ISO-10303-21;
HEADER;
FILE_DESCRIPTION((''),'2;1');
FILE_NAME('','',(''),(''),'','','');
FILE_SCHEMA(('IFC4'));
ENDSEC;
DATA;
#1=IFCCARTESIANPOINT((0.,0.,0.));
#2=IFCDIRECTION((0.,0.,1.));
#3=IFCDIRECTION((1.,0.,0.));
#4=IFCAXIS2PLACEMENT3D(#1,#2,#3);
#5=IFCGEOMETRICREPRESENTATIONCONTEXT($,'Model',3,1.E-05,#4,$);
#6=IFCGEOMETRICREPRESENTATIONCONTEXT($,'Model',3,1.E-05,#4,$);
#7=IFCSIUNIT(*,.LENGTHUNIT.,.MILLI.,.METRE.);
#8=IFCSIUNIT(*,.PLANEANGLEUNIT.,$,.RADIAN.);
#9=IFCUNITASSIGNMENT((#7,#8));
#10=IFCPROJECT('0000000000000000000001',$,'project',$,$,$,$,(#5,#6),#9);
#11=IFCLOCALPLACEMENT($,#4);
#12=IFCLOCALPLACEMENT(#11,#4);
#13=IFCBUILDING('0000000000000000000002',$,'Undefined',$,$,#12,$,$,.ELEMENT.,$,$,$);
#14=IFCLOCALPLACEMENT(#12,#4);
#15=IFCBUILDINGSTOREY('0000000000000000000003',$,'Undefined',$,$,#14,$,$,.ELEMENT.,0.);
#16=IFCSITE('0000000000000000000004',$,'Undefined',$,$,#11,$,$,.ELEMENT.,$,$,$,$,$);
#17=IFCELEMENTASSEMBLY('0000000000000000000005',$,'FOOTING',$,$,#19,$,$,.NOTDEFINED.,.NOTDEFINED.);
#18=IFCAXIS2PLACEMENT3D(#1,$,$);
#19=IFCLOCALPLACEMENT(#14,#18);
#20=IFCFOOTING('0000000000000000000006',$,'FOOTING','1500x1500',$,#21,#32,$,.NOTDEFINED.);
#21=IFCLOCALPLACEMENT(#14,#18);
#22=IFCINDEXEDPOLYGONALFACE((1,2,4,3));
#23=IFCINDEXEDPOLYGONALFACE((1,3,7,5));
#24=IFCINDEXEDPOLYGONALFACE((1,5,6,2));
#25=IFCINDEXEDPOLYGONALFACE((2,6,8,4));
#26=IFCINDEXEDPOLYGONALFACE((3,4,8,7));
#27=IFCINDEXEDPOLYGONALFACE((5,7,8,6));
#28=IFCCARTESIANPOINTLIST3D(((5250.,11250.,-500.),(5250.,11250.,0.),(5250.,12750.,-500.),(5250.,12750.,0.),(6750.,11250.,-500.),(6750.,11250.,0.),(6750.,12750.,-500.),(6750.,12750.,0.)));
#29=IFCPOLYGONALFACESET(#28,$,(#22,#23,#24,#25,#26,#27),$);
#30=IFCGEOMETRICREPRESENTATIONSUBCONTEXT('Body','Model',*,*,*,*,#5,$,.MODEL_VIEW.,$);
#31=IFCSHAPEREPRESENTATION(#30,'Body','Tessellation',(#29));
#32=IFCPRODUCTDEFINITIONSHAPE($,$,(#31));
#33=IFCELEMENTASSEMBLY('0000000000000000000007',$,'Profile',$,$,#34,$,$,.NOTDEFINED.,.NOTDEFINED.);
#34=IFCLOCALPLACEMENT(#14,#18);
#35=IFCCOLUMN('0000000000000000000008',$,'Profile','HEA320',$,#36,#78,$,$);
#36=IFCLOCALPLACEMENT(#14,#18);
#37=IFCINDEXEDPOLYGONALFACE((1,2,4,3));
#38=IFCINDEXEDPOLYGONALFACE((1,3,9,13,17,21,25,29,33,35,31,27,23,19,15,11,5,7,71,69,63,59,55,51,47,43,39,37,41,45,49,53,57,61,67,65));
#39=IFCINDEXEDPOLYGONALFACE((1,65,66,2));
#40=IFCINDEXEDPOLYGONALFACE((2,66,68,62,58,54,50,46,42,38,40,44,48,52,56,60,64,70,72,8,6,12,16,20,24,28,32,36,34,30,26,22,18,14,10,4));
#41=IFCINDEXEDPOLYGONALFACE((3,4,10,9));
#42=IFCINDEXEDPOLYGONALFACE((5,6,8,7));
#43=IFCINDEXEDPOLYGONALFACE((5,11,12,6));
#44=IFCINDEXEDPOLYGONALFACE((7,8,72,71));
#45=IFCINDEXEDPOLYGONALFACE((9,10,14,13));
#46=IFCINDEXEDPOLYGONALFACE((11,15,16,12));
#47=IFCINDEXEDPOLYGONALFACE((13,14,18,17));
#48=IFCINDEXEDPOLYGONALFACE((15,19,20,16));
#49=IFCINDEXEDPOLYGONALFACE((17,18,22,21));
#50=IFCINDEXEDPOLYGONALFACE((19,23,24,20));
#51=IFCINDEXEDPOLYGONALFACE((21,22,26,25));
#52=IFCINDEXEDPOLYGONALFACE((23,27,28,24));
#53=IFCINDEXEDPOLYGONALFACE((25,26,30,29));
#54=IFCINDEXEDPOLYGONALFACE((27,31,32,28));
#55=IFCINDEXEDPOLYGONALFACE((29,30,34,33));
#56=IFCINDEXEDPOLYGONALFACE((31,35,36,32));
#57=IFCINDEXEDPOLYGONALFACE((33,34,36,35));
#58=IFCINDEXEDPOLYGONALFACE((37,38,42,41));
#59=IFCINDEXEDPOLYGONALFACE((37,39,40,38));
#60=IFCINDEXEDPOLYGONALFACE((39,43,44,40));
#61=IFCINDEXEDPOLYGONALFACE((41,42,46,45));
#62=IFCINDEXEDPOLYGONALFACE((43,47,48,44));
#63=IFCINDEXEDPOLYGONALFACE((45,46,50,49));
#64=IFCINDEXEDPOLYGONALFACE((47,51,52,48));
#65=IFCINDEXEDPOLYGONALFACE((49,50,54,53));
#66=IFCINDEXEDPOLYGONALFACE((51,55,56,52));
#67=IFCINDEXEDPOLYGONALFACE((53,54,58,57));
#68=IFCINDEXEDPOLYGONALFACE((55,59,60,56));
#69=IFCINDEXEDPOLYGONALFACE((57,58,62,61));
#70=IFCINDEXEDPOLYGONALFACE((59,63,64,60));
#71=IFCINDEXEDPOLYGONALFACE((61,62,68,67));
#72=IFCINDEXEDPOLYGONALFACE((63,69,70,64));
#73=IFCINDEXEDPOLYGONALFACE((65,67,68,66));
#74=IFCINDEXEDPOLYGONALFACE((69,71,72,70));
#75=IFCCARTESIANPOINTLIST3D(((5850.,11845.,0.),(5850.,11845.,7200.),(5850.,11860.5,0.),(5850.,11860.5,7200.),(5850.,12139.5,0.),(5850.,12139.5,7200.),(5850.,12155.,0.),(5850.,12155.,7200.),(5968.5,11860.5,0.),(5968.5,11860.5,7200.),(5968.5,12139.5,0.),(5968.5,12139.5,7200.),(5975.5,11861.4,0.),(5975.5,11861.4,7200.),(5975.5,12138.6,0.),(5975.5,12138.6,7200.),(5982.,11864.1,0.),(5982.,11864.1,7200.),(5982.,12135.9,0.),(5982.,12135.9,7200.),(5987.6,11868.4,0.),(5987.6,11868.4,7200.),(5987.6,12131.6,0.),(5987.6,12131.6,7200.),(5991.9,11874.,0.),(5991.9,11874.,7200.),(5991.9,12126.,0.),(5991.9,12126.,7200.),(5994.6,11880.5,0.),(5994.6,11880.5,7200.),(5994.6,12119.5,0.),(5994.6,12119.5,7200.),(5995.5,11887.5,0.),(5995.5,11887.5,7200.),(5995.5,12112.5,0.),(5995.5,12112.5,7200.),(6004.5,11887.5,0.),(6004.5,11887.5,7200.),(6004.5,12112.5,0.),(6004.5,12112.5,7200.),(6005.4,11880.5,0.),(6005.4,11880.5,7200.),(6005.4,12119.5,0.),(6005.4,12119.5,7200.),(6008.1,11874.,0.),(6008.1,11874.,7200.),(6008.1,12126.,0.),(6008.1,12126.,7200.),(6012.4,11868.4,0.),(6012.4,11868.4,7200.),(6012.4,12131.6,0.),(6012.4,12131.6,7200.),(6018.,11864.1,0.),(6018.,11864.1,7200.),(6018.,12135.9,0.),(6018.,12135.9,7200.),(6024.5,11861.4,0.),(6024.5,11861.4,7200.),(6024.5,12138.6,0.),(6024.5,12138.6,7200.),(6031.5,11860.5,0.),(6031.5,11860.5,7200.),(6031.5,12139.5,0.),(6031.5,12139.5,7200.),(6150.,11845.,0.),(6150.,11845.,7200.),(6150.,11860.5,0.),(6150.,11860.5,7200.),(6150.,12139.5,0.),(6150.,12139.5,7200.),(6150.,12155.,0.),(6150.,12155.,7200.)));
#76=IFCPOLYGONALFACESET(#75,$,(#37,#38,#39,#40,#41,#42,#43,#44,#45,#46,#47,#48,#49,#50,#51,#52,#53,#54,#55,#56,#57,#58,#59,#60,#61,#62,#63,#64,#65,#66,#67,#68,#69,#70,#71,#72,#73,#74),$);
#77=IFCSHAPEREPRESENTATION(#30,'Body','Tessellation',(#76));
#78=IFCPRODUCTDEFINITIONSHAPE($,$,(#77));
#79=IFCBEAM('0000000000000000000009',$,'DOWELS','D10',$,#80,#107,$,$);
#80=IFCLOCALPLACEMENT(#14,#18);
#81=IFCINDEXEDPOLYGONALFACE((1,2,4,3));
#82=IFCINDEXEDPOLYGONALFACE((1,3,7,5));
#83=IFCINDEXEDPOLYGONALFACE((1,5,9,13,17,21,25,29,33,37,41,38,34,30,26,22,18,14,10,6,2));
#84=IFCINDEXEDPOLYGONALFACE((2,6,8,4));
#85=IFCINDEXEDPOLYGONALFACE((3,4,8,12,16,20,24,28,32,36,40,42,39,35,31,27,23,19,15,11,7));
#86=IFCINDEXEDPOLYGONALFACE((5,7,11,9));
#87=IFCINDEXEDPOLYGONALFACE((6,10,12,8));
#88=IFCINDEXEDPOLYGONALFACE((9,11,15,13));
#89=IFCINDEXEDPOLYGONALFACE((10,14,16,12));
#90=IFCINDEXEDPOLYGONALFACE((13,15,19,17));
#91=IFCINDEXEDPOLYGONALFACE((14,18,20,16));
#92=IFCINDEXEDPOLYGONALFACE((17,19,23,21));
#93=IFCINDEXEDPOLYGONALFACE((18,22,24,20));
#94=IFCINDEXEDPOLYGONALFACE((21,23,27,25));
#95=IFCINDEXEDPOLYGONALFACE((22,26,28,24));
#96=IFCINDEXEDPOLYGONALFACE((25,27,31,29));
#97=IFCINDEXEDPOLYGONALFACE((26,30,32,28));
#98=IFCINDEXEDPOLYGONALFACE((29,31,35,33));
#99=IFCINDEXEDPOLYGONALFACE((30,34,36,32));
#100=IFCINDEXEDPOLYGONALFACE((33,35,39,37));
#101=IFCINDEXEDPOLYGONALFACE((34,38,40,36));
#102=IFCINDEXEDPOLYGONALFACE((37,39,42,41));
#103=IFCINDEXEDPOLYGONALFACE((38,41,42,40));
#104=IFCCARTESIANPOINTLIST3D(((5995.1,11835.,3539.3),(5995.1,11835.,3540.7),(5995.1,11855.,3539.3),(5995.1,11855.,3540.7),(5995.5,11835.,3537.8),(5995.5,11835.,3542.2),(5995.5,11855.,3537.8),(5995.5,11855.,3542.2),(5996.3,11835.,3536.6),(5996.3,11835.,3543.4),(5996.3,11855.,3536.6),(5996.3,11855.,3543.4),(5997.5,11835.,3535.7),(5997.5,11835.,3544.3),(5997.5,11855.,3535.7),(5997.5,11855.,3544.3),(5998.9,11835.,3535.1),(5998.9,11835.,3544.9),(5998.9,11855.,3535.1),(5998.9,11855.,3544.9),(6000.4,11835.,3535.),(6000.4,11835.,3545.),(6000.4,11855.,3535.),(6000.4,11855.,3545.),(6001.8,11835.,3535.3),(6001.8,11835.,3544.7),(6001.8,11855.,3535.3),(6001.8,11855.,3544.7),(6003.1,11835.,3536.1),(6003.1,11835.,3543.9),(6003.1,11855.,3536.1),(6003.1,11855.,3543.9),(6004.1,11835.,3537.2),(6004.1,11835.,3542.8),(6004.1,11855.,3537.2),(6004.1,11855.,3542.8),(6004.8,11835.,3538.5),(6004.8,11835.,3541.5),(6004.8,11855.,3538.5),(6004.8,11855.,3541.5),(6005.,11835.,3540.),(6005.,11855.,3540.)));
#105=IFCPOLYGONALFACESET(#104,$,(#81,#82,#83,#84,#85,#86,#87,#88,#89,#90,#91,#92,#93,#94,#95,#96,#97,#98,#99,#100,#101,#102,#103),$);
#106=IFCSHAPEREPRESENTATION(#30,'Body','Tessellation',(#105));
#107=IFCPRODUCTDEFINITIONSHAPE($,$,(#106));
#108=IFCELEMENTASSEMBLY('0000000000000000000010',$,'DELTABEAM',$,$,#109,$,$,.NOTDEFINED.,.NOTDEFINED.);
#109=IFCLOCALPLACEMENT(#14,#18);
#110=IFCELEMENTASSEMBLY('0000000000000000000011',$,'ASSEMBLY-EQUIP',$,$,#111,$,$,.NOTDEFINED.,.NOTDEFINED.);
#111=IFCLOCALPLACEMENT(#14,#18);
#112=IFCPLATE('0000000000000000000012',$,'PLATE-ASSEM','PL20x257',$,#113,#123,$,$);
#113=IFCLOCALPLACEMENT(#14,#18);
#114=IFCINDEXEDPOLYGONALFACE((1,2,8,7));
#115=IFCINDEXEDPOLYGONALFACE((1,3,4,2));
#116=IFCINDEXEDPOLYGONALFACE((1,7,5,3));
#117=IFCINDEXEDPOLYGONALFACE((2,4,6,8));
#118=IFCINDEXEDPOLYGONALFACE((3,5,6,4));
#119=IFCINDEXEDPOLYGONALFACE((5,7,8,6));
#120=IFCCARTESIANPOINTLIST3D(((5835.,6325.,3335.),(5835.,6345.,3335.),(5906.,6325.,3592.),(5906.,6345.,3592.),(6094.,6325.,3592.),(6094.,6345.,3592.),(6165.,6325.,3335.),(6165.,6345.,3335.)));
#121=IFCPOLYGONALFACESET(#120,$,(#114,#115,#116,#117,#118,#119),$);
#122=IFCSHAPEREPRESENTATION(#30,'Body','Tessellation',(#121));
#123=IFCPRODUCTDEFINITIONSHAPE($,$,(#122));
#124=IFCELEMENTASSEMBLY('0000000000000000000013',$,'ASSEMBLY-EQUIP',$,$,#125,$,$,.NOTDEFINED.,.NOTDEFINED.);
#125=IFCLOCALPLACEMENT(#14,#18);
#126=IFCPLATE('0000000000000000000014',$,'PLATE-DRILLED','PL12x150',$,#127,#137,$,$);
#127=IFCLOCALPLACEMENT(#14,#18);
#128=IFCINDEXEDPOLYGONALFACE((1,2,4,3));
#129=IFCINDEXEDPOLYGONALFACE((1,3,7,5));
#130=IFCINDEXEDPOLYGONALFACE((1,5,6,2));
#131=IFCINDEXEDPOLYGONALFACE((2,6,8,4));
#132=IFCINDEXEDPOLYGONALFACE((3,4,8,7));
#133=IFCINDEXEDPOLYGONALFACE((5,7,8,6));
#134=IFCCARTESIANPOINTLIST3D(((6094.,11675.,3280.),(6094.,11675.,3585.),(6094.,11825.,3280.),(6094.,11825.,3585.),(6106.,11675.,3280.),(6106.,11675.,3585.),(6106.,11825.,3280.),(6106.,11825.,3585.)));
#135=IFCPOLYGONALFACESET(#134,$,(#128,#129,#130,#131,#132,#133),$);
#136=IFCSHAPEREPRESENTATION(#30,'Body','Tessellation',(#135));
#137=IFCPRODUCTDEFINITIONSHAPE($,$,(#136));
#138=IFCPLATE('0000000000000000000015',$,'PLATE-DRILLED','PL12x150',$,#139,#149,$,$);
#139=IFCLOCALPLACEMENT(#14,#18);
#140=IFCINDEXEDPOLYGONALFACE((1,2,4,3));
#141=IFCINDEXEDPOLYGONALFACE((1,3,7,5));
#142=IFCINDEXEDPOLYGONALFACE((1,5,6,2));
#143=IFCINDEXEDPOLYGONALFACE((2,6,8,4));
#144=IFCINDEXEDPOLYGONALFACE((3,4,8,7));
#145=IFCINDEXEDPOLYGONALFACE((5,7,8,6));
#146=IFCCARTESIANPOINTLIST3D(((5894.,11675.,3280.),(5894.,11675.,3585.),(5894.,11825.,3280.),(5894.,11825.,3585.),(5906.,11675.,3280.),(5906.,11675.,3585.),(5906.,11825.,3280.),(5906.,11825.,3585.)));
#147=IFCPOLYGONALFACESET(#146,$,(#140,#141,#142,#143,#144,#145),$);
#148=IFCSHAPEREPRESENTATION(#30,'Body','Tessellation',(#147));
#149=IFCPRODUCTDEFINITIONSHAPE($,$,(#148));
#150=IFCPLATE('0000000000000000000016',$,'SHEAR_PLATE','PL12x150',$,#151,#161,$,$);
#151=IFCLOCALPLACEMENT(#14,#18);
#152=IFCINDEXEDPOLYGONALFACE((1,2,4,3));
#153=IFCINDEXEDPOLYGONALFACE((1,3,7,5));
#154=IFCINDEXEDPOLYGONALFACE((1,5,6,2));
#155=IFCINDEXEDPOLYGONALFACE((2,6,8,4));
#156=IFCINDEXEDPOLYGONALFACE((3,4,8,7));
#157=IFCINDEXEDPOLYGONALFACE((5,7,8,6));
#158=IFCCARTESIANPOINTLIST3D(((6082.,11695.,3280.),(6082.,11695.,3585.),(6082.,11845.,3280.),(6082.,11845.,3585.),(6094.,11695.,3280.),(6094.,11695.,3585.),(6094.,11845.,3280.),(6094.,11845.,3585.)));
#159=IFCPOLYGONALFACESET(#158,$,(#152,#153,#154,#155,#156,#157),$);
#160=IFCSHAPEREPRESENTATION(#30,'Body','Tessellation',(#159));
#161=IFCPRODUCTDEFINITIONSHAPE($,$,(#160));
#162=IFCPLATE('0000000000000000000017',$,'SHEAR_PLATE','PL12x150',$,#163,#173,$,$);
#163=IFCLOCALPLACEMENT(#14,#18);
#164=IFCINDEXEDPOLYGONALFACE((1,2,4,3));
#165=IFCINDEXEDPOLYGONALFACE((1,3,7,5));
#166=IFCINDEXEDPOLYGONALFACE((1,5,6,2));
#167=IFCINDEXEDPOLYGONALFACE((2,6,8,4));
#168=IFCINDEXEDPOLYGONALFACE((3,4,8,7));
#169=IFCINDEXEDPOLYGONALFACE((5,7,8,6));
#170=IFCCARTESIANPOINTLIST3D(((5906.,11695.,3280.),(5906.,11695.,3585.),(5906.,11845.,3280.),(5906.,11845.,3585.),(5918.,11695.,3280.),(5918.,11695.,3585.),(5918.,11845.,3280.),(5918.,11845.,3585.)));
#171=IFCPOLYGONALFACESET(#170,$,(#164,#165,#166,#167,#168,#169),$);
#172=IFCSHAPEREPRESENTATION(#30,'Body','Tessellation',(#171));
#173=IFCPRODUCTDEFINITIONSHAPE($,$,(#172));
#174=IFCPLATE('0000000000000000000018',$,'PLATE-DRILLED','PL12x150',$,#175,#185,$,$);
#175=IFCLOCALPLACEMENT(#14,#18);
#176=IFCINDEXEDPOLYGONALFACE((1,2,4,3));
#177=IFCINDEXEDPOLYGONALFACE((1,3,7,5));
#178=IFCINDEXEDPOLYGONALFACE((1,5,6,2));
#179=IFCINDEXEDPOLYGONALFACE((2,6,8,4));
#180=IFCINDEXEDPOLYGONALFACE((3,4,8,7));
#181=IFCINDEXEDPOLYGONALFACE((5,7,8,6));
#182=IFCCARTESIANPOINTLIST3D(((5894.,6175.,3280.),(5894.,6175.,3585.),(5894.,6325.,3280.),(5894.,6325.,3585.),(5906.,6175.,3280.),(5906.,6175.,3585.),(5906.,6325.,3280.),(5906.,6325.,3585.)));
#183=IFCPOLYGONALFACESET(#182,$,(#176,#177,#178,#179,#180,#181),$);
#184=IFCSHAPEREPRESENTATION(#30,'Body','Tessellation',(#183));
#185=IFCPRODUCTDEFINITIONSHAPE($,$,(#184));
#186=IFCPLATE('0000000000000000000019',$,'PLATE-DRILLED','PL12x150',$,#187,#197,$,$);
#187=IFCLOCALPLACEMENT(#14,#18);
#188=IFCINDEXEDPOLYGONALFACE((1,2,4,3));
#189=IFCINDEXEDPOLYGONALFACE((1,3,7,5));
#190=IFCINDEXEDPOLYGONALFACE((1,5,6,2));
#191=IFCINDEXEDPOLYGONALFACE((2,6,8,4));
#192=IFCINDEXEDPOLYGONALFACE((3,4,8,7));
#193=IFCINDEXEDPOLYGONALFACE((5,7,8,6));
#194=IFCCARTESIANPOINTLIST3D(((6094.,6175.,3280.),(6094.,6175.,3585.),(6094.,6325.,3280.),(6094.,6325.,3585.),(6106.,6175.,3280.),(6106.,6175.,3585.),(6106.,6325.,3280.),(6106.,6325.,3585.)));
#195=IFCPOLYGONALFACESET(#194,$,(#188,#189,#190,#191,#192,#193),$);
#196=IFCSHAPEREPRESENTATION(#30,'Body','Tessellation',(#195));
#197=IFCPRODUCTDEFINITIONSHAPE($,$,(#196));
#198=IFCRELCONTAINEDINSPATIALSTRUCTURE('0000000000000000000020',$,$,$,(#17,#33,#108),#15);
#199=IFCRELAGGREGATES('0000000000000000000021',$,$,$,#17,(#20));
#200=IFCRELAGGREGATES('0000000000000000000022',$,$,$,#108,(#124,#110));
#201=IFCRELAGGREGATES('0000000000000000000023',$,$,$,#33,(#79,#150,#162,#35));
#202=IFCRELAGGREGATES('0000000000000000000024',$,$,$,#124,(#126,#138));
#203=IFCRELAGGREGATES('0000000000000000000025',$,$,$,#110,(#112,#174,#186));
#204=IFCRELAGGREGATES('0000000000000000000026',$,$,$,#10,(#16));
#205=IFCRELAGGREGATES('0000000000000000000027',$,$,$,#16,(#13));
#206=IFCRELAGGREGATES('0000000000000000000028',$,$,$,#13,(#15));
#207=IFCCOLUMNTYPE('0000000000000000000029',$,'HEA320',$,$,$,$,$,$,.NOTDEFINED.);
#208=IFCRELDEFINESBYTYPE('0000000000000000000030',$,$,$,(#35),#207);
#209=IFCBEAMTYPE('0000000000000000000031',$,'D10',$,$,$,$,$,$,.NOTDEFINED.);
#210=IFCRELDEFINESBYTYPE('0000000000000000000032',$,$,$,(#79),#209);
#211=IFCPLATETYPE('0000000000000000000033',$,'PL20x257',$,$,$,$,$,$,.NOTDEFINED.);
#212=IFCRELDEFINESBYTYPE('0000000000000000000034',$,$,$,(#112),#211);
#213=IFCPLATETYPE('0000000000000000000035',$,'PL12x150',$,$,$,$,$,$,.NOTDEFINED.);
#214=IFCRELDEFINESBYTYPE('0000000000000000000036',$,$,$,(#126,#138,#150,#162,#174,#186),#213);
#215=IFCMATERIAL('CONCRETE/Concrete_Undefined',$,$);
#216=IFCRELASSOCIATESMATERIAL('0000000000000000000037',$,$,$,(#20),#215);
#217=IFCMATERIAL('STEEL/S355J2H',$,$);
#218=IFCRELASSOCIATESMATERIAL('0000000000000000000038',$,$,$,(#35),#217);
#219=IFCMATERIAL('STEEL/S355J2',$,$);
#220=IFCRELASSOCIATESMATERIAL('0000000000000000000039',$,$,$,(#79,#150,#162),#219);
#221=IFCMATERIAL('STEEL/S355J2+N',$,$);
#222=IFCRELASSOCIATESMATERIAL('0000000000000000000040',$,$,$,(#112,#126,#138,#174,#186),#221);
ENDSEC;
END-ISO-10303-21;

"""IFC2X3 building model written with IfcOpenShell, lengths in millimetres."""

from ifc_helpers import new_model, si_unit, frame, origin_with_axes, origin_2d_with_axis, place, context, subcontext, project, spatial, polyline, rectangle, circle, i_section, outline, extrude, material, type_object, element, aggregate, save


model = new_model("IFC2X3")

# Units and contexts
model_context_1 = context("Model", 3, precision=1e-05, world=origin_with_axes())
model_context_2 = context("Model", 3, precision=1e-05, world=origin_with_axes())
body_context = subcontext(model_context_1, "Body", "Model", "MODEL_VIEW")
ifc_project = project(units=[si_unit("LENGTHUNIT", "METRE", prefix="MILLI"), si_unit("PLANEANGLEUNIT", "RADIAN")], contexts=[model_context_1, model_context_2])

# Site, building, storey
site_placement = place(None, origin_with_axes())
site = spatial("IfcSite", under=ifc_project, at=site_placement, Name="Undefined", CompositionType="ELEMENT")
building_placement = place(site_placement, origin_with_axes())
building = spatial("IfcBuilding", under=site, at=building_placement, Name="Undefined", CompositionType="ELEMENT")
storey_placement = place(building_placement, origin_with_axes())
storey = spatial("IfcBuildingStorey", under=building, at=storey_placement, Name="Undefined", CompositionType="ELEMENT", Elevation=0.0)

# Element assembly, footing
assembly_1_placement = place(storey_placement, origin_with_axes())
assembly_1 = element("IfcElementAssembly", 1, at=assembly_1_placement, inside=storey, Name="FOOTING", AssemblyPlace="NOTDEFINED", PredefinedType="NOTDEFINED")
ifc_material_1 = material(Name="CONCRETE/Concrete_Undefined")
footing_placement = place(assembly_1_placement, frame((6000.0, 12000.0, -500.0), z_axis=(0.0, 1.0, 0.0), x_axis=(0.0, 0.0, 1.0)))
footing = element("IfcFooting", 2, at=footing_placement, material=ifc_material_1, Name="FOOTING", Description="1500x1500", PredefinedType="NOTDEFINED", context=body_context, shape_type="SweptSolid", body=[
    extrude(rectangle(XDim=1500.0, YDim=1500.0, at=origin_2d_with_axis()), frame((500.0, 0.0, 0.0), z_axis=(-1.0, 0.0, 0.0), x_axis=(0.0, -1.0, 0.0)), (0.0, 0.0, 1.0), 500.0),
])
aggregate(assembly_1, [footing])

# Element assembly, column, beam
assembly_2_placement = place(storey_placement, origin_with_axes())
assembly_2 = element("IfcElementAssembly", 3, at=assembly_2_placement, inside=storey, Name="Profile", AssemblyPlace="NOTDEFINED", PredefinedType="NOTDEFINED")
ifc_material_2 = material(Name="STEEL/S355J2H")
column_type = type_object("IfcColumnType", Name="HEA320", PredefinedType="NOTDEFINED")
column_placement = place(assembly_2_placement, frame((6000.0, 12000.0, 0.0), z_axis=(0.0, 0.0, 1.0), x_axis=(0.0, 1.0, 0.0)))
column = element("IfcColumn", 4, at=column_placement, type_object=column_type, material=ifc_material_2, Name="Profile", Description="HEA320", context=body_context, shape_type="SweptSolid", body=[
    extrude(i_section(OverallWidth=300.0, OverallDepth=310.0, WebThickness=9.0, FlangeThickness=15.5, FilletRadius=27.0, at=origin_2d_with_axis()), frame((0.0, 0.0, 7200.0), z_axis=(0.0, 0.0, -1.0), x_axis=(0.0, 1.0, 0.0)), (0.0, 0.0, 1.0), 7200.0),
])
ifc_material_3 = material(Name="STEEL/S355J2")
beam_type_1 = type_object("IfcBeamType", Name="D10", PredefinedType="NOTDEFINED")
beam_1_placement = place(assembly_2_placement, frame((6000.0, 11835.0, 3540.0), z_axis=(0.0, 0.0, 1.0), x_axis=(0.0, 1.0, 0.0)))
beam_1 = element("IfcBeam", 5, at=beam_1_placement, type_object=beam_type_1, material=ifc_material_3, Name="DOWELS", Description="D10", context=body_context, shape_type="SweptSolid", body=[
    extrude(circle(Radius=5.0, at=origin_2d_with_axis()), frame((20.0, 0.0, 0.0), z_axis=(-1.0, 0.0, 0.0), x_axis=(0.0, -1.0, 0.0)), (0.0, 0.0, 1.0), 20.0),
])

# Element assemblies, plates
assembly_3_placement = place(storey_placement, origin_with_axes())
assembly_3 = element("IfcElementAssembly", 6, at=assembly_3_placement, inside=storey, Name="DELTABEAM", AssemblyPlace="NOTDEFINED", PredefinedType="NOTDEFINED")
assembly_4_placement = place(assembly_3_placement, origin_with_axes())
assembly_4 = element("IfcElementAssembly", 7, at=assembly_4_placement, Name="ASSEMBLY-EQUIP", AssemblyPlace="NOTDEFINED", PredefinedType="NOTDEFINED")
ifc_material_4 = material(Name="STEEL/S355J2+N")
plate_type_1 = type_object("IfcPlateType", Name="PL20x257", PredefinedType="NOTDEFINED")
plate_1_placement = place(assembly_4_placement, frame((6165.0, 6335.0, 3335.0), z_axis=(0.0, 1.0, 0.0), x_axis=(-1.0, 0.0, 0.0)))
plate_1 = element("IfcPlate", 8, at=plate_1_placement, type_object=plate_type_1, material=ifc_material_4, Name="PLATE-ASSEM", Description="PL20x257", context=body_context, shape_type="SweptSolid", body=[
    extrude(outline(polyline([(0.0, 0.0), (330.0, 0.0), (259.0, 257.0), (71.0, 257.0), (0.0, 0.0)])), frame((0.0, 0.0, -10.0), z_axis=(0.0, 0.0, 1.0), x_axis=(1.0, 0.0, 0.0)), (0.0, 0.0, 1.0), 20.0),
])
assembly_5_placement = place(assembly_3_placement, origin_with_axes())
assembly_5 = element("IfcElementAssembly", 9, at=assembly_5_placement, Name="ASSEMBLY-EQUIP", AssemblyPlace="NOTDEFINED", PredefinedType="NOTDEFINED")
aggregate(assembly_3, [assembly_5, assembly_4])
plate_type_2 = type_object("IfcPlateType", Name="PL12x150", PredefinedType="NOTDEFINED")
plate_2_placement = place(assembly_5_placement, frame((6100.0, 11675.0, 3585.0), z_axis=(-1.0, 0.0, 0.0), x_axis=(0.0, 1.0, 0.0)))
plate_2 = element("IfcPlate", 10, at=plate_2_placement, type_object=plate_type_2, material=ifc_material_4, Name="PLATE-DRILLED", Description="PL12x150", context=body_context, shape_type="SweptSolid", body=[
    extrude(outline(polyline([(0.0, 0.0), (150.0, 0.0), (150.0, 0.0), (150.0, 305.0), (150.0, 305.0), (0.0, 305.0), (0.0, 305.0), (0.0, 0.0)])), frame((0.0, 0.0, -6.0), z_axis=(0.0, 0.0, 1.0), x_axis=(1.0, 0.0, 0.0)), (0.0, 0.0, 1.0), 12.0),
])
plate_3_placement = place(assembly_5_placement, frame((5900.0, 11675.0, 3585.0), z_axis=(-1.0, 0.0, 0.0), x_axis=(0.0, 1.0, 0.0)))
plate_3 = element("IfcPlate", 11, at=plate_3_placement, type_object=plate_type_2, material=ifc_material_4, Name="PLATE-DRILLED", Description="PL12x150", context=body_context, shape_type="SweptSolid", body=[
    extrude(outline(polyline([(0.0, 0.0), (150.0, 0.0), (150.0, 0.0), (150.0, 305.0), (150.0, 305.0), (0.0, 305.0), (0.0, 305.0), (0.0, 0.0)])), frame((0.0, 0.0, -6.0), z_axis=(0.0, 0.0, 1.0), x_axis=(1.0, 0.0, 0.0)), (0.0, 0.0, 1.0), 12.0),
])

# Plates
plate_4_placement = place(assembly_2_placement, frame((6088.0, 11845.0, 3585.0), z_axis=(1.0, 0.0, 0.0), x_axis=(0.0, -1.0, 0.0)))
plate_4 = element("IfcPlate", 12, at=plate_4_placement, type_object=plate_type_2, material=ifc_material_3, Name="SHEAR_PLATE", Description="PL12x150", context=body_context, shape_type="SweptSolid", body=[
    extrude(outline(polyline([(0.0, 0.0), (150.0, 0.0), (150.0, 0.0), (150.0, 305.0), (150.0, 305.0), (0.0, 305.0), (0.0, 305.0), (0.0, 0.0)])), frame((0.0, 0.0, -6.0), z_axis=(0.0, 0.0, 1.0), x_axis=(1.0, 0.0, 0.0)), (0.0, 0.0, 1.0), 12.0),
])
plate_5_placement = place(assembly_2_placement, frame((5912.0, 11845.0, 3585.0), z_axis=(1.0, 0.0, 0.0), x_axis=(0.0, -1.0, 0.0)))
plate_5 = element("IfcPlate", 13, at=plate_5_placement, type_object=plate_type_2, material=ifc_material_3, Name="SHEAR_PLATE", Description="PL12x150", context=body_context, shape_type="SweptSolid", body=[
    extrude(outline(polyline([(0.0, 0.0), (150.0, 0.0), (150.0, 0.0), (150.0, 305.0), (150.0, 305.0), (0.0, 305.0), (0.0, 305.0), (0.0, 0.0)])), frame((0.0, 0.0, -6.0), z_axis=(0.0, 0.0, 1.0), x_axis=(1.0, 0.0, 0.0)), (0.0, 0.0, 1.0), 12.0),
])
aggregate(assembly_2, [beam_1, plate_4, plate_5, column])
plate_6_placement = place(assembly_4_placement, frame((5900.0, 6325.0, 3585.0), z_axis=(1.0, 0.0, 0.0), x_axis=(0.0, -1.0, 0.0)))
plate_6 = element("IfcPlate", 14, at=plate_6_placement, type_object=plate_type_2, material=ifc_material_4, Name="PLATE-DRILLED", Description="PL12x150", context=body_context, shape_type="SweptSolid", body=[
    extrude(outline(polyline([(0.0, 0.0), (150.0, 0.0), (150.0, 0.0), (150.0, 305.0), (150.0, 305.0), (0.0, 305.0), (0.0, 305.0), (0.0, 0.0)])), frame((0.0, 0.0, -6.0), z_axis=(0.0, 0.0, 1.0), x_axis=(1.0, 0.0, 0.0)), (0.0, 0.0, 1.0), 12.0),
])
plate_7_placement = place(assembly_4_placement, frame((6100.0, 6325.0, 3585.0), z_axis=(1.0, 0.0, 0.0), x_axis=(0.0, -1.0, 0.0)))
plate_7 = element("IfcPlate", 15, at=plate_7_placement, type_object=plate_type_2, material=ifc_material_4, Name="PLATE-DRILLED", Description="PL12x150", context=body_context, shape_type="SweptSolid", body=[
    extrude(outline(polyline([(0.0, 0.0), (150.0, 0.0), (150.0, 0.0), (150.0, 305.0), (150.0, 305.0), (0.0, 305.0), (0.0, 305.0), (0.0, 0.0)])), frame((0.0, 0.0, -6.0), z_axis=(0.0, 0.0, 1.0), x_axis=(1.0, 0.0, 0.0)), (0.0, 0.0, 1.0), 12.0),
])

aggregate(assembly_5, [plate_2, plate_3])
aggregate(assembly_4, [plate_1, plate_6, plate_7])

save(model, "model.ifc")
